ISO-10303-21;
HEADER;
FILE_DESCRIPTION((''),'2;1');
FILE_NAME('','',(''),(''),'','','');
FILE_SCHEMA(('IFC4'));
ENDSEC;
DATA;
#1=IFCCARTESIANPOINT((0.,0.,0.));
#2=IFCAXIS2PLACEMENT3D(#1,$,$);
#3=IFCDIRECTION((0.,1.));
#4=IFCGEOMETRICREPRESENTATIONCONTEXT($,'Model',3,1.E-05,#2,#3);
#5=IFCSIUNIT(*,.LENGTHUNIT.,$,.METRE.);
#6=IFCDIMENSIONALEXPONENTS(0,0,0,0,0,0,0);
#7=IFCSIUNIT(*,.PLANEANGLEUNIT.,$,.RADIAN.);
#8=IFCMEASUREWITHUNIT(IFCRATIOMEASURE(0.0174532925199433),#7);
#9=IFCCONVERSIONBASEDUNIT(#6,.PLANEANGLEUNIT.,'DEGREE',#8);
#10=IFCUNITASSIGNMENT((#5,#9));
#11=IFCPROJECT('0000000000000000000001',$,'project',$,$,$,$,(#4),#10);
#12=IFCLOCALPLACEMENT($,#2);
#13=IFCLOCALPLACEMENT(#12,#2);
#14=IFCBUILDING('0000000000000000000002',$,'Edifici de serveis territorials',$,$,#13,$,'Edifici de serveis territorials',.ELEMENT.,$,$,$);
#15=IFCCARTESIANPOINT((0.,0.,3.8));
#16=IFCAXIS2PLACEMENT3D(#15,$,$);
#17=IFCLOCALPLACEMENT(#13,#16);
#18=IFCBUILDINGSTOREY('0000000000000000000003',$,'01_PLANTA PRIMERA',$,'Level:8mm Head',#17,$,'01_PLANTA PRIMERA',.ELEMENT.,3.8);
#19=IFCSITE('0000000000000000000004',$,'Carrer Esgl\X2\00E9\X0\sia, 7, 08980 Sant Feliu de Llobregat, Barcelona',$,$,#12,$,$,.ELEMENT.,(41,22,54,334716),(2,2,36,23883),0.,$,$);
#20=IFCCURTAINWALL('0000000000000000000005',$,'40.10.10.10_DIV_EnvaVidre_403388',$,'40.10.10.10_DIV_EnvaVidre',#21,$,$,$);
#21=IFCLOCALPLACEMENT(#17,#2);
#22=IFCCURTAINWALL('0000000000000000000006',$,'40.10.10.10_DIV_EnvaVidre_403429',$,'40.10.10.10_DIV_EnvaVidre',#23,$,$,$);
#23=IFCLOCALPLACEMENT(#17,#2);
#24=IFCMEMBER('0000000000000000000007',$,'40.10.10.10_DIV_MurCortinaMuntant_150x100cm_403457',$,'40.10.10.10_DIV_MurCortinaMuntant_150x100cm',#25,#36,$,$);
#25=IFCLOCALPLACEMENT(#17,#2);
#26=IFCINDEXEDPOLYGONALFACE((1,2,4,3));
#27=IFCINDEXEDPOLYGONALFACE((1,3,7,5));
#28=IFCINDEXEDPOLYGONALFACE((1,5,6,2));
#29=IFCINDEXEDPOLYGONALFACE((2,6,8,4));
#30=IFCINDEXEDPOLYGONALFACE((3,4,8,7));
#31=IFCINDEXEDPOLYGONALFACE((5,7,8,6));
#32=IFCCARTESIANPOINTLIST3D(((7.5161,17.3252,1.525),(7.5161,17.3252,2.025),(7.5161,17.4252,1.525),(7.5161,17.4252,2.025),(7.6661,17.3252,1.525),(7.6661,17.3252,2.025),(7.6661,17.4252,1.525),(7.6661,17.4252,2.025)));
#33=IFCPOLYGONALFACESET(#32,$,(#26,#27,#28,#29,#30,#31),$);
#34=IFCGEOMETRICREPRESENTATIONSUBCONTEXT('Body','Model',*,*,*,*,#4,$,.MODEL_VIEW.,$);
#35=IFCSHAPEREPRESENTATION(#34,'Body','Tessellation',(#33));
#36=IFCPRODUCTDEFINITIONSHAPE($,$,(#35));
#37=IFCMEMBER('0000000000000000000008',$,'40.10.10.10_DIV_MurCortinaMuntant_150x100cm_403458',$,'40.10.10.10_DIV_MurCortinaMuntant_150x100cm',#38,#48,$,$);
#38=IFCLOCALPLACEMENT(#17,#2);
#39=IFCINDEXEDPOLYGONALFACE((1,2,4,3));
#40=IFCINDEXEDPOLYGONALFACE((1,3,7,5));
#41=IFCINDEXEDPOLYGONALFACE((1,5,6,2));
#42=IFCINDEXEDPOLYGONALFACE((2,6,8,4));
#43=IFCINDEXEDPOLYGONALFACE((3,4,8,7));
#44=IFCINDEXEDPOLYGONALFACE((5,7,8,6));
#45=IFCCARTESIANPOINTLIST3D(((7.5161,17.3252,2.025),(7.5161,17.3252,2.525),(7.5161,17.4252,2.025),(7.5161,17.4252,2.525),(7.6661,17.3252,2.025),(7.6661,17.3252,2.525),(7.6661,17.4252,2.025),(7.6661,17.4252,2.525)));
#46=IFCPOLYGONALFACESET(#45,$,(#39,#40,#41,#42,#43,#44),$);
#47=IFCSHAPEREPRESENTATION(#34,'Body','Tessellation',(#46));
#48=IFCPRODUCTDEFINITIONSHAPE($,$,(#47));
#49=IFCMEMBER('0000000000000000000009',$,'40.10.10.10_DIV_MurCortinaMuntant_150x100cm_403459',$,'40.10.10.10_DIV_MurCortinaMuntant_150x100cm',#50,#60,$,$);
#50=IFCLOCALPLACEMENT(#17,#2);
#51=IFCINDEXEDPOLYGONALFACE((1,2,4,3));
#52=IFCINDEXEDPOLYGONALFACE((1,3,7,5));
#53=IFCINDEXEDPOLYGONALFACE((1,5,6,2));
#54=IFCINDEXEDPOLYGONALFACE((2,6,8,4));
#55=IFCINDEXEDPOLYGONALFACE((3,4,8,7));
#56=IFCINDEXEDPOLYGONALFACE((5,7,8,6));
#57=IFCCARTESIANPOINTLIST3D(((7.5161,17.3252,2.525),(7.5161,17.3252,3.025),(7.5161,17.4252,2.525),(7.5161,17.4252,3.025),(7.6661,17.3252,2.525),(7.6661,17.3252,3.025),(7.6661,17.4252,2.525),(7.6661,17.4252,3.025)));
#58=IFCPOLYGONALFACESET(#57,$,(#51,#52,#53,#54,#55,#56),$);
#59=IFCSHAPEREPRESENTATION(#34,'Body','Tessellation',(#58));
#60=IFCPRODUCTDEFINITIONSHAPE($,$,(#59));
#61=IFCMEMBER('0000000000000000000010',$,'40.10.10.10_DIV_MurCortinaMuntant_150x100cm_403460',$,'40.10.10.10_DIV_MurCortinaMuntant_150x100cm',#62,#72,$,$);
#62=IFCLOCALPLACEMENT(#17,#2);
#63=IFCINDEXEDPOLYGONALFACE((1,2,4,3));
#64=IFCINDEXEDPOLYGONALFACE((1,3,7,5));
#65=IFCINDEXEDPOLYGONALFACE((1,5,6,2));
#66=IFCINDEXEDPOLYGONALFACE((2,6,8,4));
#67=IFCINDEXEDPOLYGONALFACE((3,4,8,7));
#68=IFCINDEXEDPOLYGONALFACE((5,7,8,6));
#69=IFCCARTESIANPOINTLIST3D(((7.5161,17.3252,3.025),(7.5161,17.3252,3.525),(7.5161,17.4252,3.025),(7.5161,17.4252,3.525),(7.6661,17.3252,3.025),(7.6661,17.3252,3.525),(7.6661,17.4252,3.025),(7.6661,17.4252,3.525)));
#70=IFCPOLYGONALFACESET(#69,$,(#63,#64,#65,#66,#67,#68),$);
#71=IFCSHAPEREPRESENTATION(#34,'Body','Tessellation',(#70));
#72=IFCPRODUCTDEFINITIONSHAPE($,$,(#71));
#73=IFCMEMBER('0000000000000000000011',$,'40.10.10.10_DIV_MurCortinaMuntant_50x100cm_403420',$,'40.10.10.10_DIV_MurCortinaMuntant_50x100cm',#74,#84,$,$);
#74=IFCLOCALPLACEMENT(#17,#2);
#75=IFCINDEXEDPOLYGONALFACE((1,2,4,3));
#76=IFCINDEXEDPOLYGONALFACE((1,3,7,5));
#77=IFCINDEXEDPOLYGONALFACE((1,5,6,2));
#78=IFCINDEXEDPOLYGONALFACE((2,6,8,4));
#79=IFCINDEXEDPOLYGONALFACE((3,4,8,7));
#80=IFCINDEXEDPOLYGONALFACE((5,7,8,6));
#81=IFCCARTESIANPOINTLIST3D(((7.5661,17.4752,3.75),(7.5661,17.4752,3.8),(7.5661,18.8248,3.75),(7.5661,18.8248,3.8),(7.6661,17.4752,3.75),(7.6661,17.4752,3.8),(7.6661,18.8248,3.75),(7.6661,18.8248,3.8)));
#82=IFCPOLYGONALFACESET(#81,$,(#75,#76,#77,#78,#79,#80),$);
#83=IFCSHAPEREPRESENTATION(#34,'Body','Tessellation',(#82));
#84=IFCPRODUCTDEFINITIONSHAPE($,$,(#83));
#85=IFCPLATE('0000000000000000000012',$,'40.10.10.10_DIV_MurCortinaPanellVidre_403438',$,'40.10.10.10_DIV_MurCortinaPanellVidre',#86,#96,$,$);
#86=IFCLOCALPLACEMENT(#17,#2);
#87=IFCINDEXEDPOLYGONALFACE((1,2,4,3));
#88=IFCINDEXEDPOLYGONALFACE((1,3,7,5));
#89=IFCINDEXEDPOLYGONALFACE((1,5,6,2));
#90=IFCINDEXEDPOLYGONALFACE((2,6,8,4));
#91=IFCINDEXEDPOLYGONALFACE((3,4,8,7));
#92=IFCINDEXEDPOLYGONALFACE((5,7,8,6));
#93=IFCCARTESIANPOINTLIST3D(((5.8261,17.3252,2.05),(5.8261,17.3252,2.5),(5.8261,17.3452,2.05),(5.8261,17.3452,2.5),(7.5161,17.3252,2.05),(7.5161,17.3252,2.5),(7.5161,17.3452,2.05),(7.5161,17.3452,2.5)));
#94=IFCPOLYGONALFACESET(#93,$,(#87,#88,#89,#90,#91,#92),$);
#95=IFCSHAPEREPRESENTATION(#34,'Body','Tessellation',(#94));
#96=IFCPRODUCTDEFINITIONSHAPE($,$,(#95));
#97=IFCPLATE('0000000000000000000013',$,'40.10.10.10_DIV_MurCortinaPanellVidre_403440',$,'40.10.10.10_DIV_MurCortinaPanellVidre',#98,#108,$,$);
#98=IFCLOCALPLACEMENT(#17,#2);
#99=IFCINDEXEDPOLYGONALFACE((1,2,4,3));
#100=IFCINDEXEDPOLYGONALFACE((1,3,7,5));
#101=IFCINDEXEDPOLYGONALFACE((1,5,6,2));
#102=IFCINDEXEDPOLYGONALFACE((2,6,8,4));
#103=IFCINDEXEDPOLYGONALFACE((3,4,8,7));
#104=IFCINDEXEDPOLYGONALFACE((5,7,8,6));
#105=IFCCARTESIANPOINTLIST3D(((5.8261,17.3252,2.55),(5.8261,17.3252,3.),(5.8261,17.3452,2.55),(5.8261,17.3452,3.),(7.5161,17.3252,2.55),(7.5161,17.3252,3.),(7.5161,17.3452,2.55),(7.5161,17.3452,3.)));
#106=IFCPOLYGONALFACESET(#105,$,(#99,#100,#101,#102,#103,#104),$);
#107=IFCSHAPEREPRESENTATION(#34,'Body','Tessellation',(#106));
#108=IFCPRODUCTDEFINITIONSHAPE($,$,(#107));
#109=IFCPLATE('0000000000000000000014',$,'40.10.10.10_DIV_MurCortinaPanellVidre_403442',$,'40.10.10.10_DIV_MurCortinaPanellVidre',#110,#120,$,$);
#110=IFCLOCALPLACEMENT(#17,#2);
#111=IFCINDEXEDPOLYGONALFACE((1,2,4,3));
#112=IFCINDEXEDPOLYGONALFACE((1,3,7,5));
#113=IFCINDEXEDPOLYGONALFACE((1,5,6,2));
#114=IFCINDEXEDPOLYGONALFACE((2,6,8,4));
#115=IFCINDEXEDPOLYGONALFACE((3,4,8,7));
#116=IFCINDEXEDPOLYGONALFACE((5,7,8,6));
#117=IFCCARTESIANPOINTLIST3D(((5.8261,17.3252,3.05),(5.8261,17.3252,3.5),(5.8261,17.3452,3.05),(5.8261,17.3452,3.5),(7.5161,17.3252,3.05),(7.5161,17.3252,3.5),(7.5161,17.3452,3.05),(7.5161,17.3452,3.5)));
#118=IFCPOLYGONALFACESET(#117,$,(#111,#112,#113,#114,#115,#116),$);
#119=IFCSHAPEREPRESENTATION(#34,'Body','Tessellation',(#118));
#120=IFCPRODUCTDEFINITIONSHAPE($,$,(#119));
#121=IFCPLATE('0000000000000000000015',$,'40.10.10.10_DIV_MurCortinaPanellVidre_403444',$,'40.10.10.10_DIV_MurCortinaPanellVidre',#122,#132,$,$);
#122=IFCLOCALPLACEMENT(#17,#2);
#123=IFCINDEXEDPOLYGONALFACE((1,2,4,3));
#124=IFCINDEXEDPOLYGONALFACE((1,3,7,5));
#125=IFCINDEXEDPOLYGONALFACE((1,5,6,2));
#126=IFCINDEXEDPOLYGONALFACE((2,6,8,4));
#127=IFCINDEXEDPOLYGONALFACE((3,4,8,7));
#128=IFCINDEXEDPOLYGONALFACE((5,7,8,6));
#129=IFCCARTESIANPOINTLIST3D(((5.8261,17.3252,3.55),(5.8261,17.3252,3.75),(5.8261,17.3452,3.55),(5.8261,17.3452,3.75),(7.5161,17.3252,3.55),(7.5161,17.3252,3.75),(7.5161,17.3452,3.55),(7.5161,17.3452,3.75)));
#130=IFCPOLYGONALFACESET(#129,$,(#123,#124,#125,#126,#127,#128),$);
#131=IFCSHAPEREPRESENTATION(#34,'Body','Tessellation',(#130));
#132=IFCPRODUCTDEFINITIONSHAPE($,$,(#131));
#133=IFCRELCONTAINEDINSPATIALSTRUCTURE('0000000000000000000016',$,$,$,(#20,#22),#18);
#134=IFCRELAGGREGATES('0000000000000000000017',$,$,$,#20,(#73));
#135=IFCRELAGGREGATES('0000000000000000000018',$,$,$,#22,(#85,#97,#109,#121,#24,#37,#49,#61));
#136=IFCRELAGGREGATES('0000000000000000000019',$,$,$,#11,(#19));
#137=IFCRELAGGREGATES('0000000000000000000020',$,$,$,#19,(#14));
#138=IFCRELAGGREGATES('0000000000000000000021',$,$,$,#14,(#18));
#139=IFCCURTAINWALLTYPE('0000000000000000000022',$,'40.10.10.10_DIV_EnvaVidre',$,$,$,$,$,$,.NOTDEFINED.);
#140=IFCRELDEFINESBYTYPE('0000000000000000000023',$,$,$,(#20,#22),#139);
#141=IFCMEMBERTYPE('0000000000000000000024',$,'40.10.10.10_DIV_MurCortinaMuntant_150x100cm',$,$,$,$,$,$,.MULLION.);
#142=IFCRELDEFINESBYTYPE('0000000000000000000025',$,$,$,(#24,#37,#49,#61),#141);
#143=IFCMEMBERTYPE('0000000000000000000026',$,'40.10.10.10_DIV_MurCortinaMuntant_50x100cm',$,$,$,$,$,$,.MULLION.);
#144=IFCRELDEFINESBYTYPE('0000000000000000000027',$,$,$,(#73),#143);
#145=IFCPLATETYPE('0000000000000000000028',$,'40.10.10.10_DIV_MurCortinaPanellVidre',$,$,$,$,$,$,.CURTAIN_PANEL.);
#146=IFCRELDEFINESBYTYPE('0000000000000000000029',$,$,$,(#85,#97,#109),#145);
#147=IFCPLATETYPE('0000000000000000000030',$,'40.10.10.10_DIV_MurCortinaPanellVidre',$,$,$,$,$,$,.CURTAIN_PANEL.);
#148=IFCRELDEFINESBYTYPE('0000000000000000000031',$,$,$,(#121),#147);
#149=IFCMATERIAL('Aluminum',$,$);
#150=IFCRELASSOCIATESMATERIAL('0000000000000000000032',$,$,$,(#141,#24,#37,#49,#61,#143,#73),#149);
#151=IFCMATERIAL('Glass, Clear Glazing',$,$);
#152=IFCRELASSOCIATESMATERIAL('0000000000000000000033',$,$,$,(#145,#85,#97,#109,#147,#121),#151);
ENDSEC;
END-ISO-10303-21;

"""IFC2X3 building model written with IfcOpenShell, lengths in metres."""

from ifc_helpers import new_model, entity, si_unit, converted_unit, direction, frame, frame_2d, origin, origin_2d_with_axis, place, context, subcontext, project, spatial, rectangle, extrude, source, transform, mapped, material, type_object, type_shapes, element, aggregate, save


model = new_model("IFC2X3")

# Units and contexts
model_context = context("Model", 3, precision=1e-05, world=origin(), true_north=direction((0.0, 1.0)))
body_context = subcontext(model_context, "Body", "Model", "MODEL_VIEW")
ifc_project = project(units=[si_unit("LENGTHUNIT", "METRE"), converted_unit("PLANEANGLEUNIT", "DEGREE", entity("IfcRatioMeasure", 0.0174532925199433), si_unit("PLANEANGLEUNIT", "RADIAN"), dimensions=[0, 0, 0, 0, 0, 0, 0])], contexts=[model_context])

# Site, building, storey
site_placement = place(None, origin())
site = spatial("IfcSite", under=ifc_project, at=site_placement, Name="Carrer Església, 7, 08980 Sant Feliu de Llobregat, Barcelona", CompositionType="ELEMENT", RefLatitude=(41, 22, 54, 334716), RefLongitude=(2, 2, 36, 23883), RefElevation=0.0)
building_placement = place(site_placement, origin())
building = spatial("IfcBuilding", under=site, at=building_placement, Name="Edifici de serveis territorials", LongName="Edifici de serveis territorials", CompositionType="ELEMENT")
storey_placement = place(building_placement, frame((0.0, 0.0, 3.8)))
storey = spatial("IfcBuildingStorey", under=building, at=storey_placement, Name="01_PLANTA PRIMERA", ObjectType="Level:8mm Head", LongName="01_PLANTA PRIMERA", CompositionType="ELEMENT", Elevation=3.8)

# Curtain walls
curtain_wall_type = type_object("IfcCurtainWallType", Name="40.10.10.10_DIV_EnvaVidre", PredefinedType="NOTDEFINED")
curtain_wall_1_placement = place(storey_placement, frame((0.0, 0.0, -3.8)))
curtain_wall_1 = element("IfcCurtainWall", 1, at=curtain_wall_1_placement, inside=storey, type_object=curtain_wall_type, Name="40.10.10.10_DIV_EnvaVidre_403388", ObjectType="40.10.10.10_DIV_EnvaVidre")
ifc_material_1 = material(Name="Aluminum")
curtain_wall_2_placement = place(storey_placement, frame((0.0, 0.0, -3.8)))
curtain_wall_2 = element("IfcCurtainWall", 2, at=curtain_wall_2_placement, inside=storey, type_object=curtain_wall_type, Name="40.10.10.10_DIV_EnvaVidre_403429", ObjectType="40.10.10.10_DIV_EnvaVidre")

# Members
member_type_1 = type_object("IfcMemberType", Name="40.10.10.10_DIV_MurCortinaMuntant_150x100cm", PredefinedType="MULLION", material=ifc_material_1)
shared_shape_1 = source(origin(), body_context, "Body", "SweptSolid", [
    extrude(rectangle(XDim=0.1, YDim=0.15, at=origin_2d_with_axis()), frame((-0.075, 0.0, -0.5), z_axis=(0.0, 0.0, 1.0), x_axis=(0.0, -1.0, 0.0)), (0.0, 0.0, 1.0), 0.5),
])
type_shapes(member_type_1, [shared_shape_1])
member_1_placement = place(storey_placement, frame((7.6661, 17.3752, 2.025)))
member_1 = element("IfcMember", 3, at=member_1_placement, type_object=member_type_1, material=ifc_material_1, Name="40.10.10.10_DIV_MurCortinaMuntant_150x100cm_403457", ObjectType="40.10.10.10_DIV_MurCortinaMuntant_150x100cm", context=body_context, shape_type="MappedRepresentation", body=[
    mapped(shared_shape_1, transform((0.0, 0.0, 0.0), scale=1.0)),
])
member_2_placement = place(storey_placement, frame((7.6661, 17.3752, 2.525)))
member_2 = element("IfcMember", 4, at=member_2_placement, type_object=member_type_1, material=ifc_material_1, Name="40.10.10.10_DIV_MurCortinaMuntant_150x100cm_403458", ObjectType="40.10.10.10_DIV_MurCortinaMuntant_150x100cm", context=body_context, shape_type="MappedRepresentation", body=[
    mapped(shared_shape_1, transform((0.0, 0.0, 0.0), scale=1.0)),
])
member_3_placement = place(storey_placement, frame((7.6661, 17.3752, 3.025)))
member_3 = element("IfcMember", 5, at=member_3_placement, type_object=member_type_1, material=ifc_material_1, Name="40.10.10.10_DIV_MurCortinaMuntant_150x100cm_403459", ObjectType="40.10.10.10_DIV_MurCortinaMuntant_150x100cm", context=body_context, shape_type="MappedRepresentation", body=[
    mapped(shared_shape_1, transform((0.0, 0.0, 0.0), scale=1.0)),
])
member_4_placement = place(storey_placement, frame((7.6661, 17.3752, 3.525)))
member_4 = element("IfcMember", 6, at=member_4_placement, type_object=member_type_1, material=ifc_material_1, Name="40.10.10.10_DIV_MurCortinaMuntant_150x100cm_403460", ObjectType="40.10.10.10_DIV_MurCortinaMuntant_150x100cm", context=body_context, shape_type="MappedRepresentation", body=[
    mapped(shared_shape_1, transform((0.0, 0.0, 0.0), scale=1.0)),
])
member_type_2 = type_object("IfcMemberType", Name="40.10.10.10_DIV_MurCortinaMuntant_50x100cm", PredefinedType="MULLION", material=ifc_material_1)
shared_shape_2 = source(origin(), body_context, "Body", "SweptSolid", [
    extrude(rectangle(XDim=0.1, YDim=0.05, at=origin_2d_with_axis()), frame((-0.025, 0.0, -1.3496), z_axis=(0.0, 0.0, 1.0), x_axis=(0.0, -1.0, 0.0)), (0.0, 0.0, 1.0), 1.3496),
])
type_shapes(member_type_2, [shared_shape_2])
member_5_placement = place(storey_placement, frame((7.6161, 17.4752, 3.8), z_axis=(0.0, -1.0, 0.0), x_axis=(0.0, 0.0, 1.0)))
member_5 = element("IfcMember", 7, at=member_5_placement, type_object=member_type_2, material=ifc_material_1, Name="40.10.10.10_DIV_MurCortinaMuntant_50x100cm_403420", ObjectType="40.10.10.10_DIV_MurCortinaMuntant_50x100cm", context=body_context, shape_type="MappedRepresentation", body=[
    mapped(shared_shape_2, transform((0.0, 0.0, 0.0), scale=1.0)),
])
aggregate(curtain_wall_1, [member_5])

# Plates
ifc_material_2 = material(Name="Glass, Clear Glazing")
plate_type_1 = type_object("IfcPlateType", Name="40.10.10.10_DIV_MurCortinaPanellVidre", PredefinedType="CURTAIN_PANEL", material=ifc_material_2)
shared_shape_3 = source(origin(), body_context, "Body", "SweptSolid", [
    extrude(rectangle(XDim=0.02, YDim=1.69, at=frame_2d((0.0, 0.0), x_axis=(1.0, 0.0))), frame((0.845, 0.01, 0.0), z_axis=(0.0, 0.0, 1.0), x_axis=(0.0, 1.0, 0.0)), (0.0, 0.0, 1.0), 0.45),
])
type_shapes(plate_type_1, [shared_shape_3])
plate_1_placement = place(curtain_wall_2_placement, frame((7.5161, 17.3452, 5.85), z_axis=(0.0, 0.0, 1.0), x_axis=(-1.0, 0.0, 0.0)))
plate_1 = element("IfcPlate", 8, at=plate_1_placement, type_object=plate_type_1, material=ifc_material_2, Name="40.10.10.10_DIV_MurCortinaPanellVidre_403438", ObjectType="40.10.10.10_DIV_MurCortinaPanellVidre", context=body_context, shape_type="MappedRepresentation", body=[
    mapped(shared_shape_3, transform((0.0, 0.0, 0.0), scale=1.0)),
])
plate_2_placement = place(curtain_wall_2_placement, frame((7.5161, 17.3452, 6.35), z_axis=(0.0, 0.0, 1.0), x_axis=(-1.0, 0.0, 0.0)))
plate_2 = element("IfcPlate", 9, at=plate_2_placement, type_object=plate_type_1, material=ifc_material_2, Name="40.10.10.10_DIV_MurCortinaPanellVidre_403440", ObjectType="40.10.10.10_DIV_MurCortinaPanellVidre", context=body_context, shape_type="MappedRepresentation", body=[
    mapped(shared_shape_3, transform((0.0, 0.0, 0.0), scale=1.0)),
])
plate_3_placement = place(curtain_wall_2_placement, frame((7.5161, 17.3452, 6.85), z_axis=(0.0, 0.0, 1.0), x_axis=(-1.0, 0.0, 0.0)))
plate_3 = element("IfcPlate", 10, at=plate_3_placement, type_object=plate_type_1, material=ifc_material_2, Name="40.10.10.10_DIV_MurCortinaPanellVidre_403442", ObjectType="40.10.10.10_DIV_MurCortinaPanellVidre", context=body_context, shape_type="MappedRepresentation", body=[
    mapped(shared_shape_3, transform((0.0, 0.0, 0.0), scale=1.0)),
])
plate_type_2 = type_object("IfcPlateType", Name="40.10.10.10_DIV_MurCortinaPanellVidre", PredefinedType="CURTAIN_PANEL", material=ifc_material_2)
shared_shape_4 = source(origin(), body_context, "Body", "SweptSolid", [
    extrude(rectangle(XDim=0.02, YDim=1.69, at=frame_2d((0.0, 0.0), x_axis=(1.0, 0.0))), frame((0.845, 0.01, 0.0), z_axis=(0.0, 0.0, 1.0), x_axis=(0.0, 1.0, 0.0)), (0.0, 0.0, 1.0), 0.2),
])
type_shapes(plate_type_2, [shared_shape_4])
plate_4_placement = place(curtain_wall_2_placement, frame((7.5161, 17.3452, 7.35), z_axis=(0.0, 0.0, 1.0), x_axis=(-1.0, 0.0, 0.0)))
plate_4 = element("IfcPlate", 11, at=plate_4_placement, type_object=plate_type_2, material=ifc_material_2, Name="40.10.10.10_DIV_MurCortinaPanellVidre_403444", ObjectType="40.10.10.10_DIV_MurCortinaPanellVidre", context=body_context, shape_type="MappedRepresentation", body=[
    mapped(shared_shape_4, transform((0.0, 0.0, 0.0), scale=1.0)),
])
aggregate(curtain_wall_2, [plate_1, plate_2, plate_3, plate_4, member_1, member_2, member_3, member_4])

save(model, "model.ifc")
